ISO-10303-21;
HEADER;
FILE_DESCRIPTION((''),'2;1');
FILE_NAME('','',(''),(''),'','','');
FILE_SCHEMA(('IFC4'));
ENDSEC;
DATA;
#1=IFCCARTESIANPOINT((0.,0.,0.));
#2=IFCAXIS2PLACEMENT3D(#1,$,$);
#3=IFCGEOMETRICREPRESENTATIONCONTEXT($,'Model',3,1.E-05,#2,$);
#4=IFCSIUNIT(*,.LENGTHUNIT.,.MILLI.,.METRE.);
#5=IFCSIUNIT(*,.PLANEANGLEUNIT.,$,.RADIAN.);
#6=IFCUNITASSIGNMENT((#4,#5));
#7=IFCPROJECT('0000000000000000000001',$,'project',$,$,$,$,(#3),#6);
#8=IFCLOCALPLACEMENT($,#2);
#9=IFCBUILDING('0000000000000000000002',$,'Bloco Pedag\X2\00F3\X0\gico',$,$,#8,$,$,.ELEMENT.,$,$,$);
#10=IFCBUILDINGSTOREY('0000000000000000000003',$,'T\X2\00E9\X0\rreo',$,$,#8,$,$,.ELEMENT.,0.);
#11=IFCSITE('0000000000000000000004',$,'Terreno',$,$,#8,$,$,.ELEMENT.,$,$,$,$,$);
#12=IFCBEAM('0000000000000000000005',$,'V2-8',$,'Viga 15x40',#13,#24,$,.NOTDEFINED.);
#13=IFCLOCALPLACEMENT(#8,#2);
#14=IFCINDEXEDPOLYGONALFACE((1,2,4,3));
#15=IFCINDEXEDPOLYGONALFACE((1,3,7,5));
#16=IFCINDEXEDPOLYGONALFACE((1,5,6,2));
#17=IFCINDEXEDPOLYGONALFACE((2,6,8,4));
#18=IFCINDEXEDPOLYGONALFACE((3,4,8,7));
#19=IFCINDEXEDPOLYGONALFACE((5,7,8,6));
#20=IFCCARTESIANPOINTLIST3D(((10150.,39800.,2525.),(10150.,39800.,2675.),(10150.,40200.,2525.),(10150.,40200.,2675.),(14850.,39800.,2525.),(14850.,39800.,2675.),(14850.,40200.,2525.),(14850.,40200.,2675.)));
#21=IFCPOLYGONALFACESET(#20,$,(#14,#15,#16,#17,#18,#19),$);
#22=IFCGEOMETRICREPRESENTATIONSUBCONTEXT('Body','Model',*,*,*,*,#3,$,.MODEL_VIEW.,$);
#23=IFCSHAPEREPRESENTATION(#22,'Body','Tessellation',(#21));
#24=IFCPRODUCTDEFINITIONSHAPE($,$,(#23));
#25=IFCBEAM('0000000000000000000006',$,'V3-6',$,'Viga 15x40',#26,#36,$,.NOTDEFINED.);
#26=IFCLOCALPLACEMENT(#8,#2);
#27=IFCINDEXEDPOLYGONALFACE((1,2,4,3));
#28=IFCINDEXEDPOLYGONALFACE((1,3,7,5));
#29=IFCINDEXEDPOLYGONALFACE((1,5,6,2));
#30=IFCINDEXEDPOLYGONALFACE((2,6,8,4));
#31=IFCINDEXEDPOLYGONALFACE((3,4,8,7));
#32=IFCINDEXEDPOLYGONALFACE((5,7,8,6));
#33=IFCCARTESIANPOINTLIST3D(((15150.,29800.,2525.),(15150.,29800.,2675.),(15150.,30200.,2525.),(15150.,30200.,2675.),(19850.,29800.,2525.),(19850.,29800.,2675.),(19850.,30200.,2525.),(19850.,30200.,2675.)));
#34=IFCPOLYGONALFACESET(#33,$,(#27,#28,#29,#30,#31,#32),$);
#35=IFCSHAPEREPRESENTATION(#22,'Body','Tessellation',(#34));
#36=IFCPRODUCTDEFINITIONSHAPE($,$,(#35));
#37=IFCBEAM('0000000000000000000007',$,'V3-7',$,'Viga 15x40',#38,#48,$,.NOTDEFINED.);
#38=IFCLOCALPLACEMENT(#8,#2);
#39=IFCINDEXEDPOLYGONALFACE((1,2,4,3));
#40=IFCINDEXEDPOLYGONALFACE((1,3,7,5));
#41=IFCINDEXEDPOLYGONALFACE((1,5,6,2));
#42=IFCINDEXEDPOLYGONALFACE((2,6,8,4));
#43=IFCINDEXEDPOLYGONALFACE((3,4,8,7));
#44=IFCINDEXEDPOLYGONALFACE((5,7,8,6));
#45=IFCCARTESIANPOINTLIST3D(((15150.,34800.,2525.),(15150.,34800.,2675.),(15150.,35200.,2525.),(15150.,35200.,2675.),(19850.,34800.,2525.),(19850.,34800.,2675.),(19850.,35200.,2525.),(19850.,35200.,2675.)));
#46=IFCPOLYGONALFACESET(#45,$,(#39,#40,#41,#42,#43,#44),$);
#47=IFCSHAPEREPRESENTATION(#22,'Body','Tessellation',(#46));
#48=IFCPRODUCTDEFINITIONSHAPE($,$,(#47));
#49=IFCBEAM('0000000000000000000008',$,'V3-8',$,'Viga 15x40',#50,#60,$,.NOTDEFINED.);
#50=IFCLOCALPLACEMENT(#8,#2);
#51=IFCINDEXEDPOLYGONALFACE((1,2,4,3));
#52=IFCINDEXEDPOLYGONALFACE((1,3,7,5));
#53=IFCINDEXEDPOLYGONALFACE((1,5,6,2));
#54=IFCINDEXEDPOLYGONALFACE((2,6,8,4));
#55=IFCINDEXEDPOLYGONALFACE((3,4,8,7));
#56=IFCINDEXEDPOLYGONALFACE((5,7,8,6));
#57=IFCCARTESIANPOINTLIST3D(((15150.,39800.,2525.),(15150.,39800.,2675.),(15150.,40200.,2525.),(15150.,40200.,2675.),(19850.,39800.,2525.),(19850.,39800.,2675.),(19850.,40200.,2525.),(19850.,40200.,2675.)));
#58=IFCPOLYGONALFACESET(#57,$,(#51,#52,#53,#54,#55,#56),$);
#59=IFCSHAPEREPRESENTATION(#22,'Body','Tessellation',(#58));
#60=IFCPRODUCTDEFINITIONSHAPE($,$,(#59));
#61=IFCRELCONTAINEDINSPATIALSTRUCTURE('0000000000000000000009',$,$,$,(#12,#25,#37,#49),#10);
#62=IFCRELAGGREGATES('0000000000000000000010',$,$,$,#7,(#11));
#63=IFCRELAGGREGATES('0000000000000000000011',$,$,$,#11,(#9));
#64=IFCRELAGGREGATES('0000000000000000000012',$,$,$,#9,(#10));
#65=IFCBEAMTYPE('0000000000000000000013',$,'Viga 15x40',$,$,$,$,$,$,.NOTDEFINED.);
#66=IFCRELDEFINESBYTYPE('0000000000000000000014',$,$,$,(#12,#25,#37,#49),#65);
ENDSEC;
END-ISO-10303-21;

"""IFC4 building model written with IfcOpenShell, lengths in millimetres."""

from ifc_helpers import new_model, si_unit, frame, origin, origin_2d, place, context, subcontext, project, spatial, rectangle, extrude, type_object, element, save


model = new_model("IFC4")

# Units and contexts
model_context = context("Model", 3, precision=1e-05, world=origin())
body_context = subcontext(model_context, "Body", "Model", "MODEL_VIEW")
ifc_project = project(units=[si_unit("LENGTHUNIT", "METRE", prefix="MILLI"), si_unit("PLANEANGLEUNIT", "RADIAN")], contexts=[model_context])

# Site, building, storey
placement = place(None, origin())
site = spatial("IfcSite", under=ifc_project, at=placement, Name="Terreno", CompositionType="ELEMENT")
building = spatial("IfcBuilding", under=site, at=placement, Name="Bloco Pedagógico", CompositionType="ELEMENT")
storey = spatial("IfcBuildingStorey", under=building, at=placement, Name="Térreo", CompositionType="ELEMENT", Elevation=0.0)

# Beams
beam_type = type_object("IfcBeamType", Name="Viga 15x40", PredefinedType="NOTDEFINED")
for number, where, z_axis, x_axis, name in (
    (1, (10150.0, 40000.0, 2600.0), (1.0, 0.0, 0.0), (0.0, 1.0, 0.0), "V2-8"),
    (2, (15150.0, 30000.0, 2600.0), (1.0, 0.0, 0.0), (0.0, 1.0, 0.0), "V3-6"),
    (3, (15150.0, 35000.0, 2600.0), (1.0, 0.0, 0.0), (0.0, 1.0, 0.0), "V3-7"),
    (4, (15150.0, 40000.0, 2600.0), (1.0, 0.0, 0.0), (0.0, 1.0, 0.0), "V3-8"),
):
    element("IfcBeam", number, at=place(None, frame(where, z_axis=z_axis, x_axis=x_axis)), inside=storey, type_object=beam_type, Name=name, ObjectType="Viga 15x40", PredefinedType="NOTDEFINED", context=body_context, shape_type="SweptSolid", body=[
        extrude(rectangle(XDim=400.0, YDim=150.0, at=origin_2d()), None, (0.0, 0.0, 1.0), 4700.0),
    ])

save(model, "model.ifc")
